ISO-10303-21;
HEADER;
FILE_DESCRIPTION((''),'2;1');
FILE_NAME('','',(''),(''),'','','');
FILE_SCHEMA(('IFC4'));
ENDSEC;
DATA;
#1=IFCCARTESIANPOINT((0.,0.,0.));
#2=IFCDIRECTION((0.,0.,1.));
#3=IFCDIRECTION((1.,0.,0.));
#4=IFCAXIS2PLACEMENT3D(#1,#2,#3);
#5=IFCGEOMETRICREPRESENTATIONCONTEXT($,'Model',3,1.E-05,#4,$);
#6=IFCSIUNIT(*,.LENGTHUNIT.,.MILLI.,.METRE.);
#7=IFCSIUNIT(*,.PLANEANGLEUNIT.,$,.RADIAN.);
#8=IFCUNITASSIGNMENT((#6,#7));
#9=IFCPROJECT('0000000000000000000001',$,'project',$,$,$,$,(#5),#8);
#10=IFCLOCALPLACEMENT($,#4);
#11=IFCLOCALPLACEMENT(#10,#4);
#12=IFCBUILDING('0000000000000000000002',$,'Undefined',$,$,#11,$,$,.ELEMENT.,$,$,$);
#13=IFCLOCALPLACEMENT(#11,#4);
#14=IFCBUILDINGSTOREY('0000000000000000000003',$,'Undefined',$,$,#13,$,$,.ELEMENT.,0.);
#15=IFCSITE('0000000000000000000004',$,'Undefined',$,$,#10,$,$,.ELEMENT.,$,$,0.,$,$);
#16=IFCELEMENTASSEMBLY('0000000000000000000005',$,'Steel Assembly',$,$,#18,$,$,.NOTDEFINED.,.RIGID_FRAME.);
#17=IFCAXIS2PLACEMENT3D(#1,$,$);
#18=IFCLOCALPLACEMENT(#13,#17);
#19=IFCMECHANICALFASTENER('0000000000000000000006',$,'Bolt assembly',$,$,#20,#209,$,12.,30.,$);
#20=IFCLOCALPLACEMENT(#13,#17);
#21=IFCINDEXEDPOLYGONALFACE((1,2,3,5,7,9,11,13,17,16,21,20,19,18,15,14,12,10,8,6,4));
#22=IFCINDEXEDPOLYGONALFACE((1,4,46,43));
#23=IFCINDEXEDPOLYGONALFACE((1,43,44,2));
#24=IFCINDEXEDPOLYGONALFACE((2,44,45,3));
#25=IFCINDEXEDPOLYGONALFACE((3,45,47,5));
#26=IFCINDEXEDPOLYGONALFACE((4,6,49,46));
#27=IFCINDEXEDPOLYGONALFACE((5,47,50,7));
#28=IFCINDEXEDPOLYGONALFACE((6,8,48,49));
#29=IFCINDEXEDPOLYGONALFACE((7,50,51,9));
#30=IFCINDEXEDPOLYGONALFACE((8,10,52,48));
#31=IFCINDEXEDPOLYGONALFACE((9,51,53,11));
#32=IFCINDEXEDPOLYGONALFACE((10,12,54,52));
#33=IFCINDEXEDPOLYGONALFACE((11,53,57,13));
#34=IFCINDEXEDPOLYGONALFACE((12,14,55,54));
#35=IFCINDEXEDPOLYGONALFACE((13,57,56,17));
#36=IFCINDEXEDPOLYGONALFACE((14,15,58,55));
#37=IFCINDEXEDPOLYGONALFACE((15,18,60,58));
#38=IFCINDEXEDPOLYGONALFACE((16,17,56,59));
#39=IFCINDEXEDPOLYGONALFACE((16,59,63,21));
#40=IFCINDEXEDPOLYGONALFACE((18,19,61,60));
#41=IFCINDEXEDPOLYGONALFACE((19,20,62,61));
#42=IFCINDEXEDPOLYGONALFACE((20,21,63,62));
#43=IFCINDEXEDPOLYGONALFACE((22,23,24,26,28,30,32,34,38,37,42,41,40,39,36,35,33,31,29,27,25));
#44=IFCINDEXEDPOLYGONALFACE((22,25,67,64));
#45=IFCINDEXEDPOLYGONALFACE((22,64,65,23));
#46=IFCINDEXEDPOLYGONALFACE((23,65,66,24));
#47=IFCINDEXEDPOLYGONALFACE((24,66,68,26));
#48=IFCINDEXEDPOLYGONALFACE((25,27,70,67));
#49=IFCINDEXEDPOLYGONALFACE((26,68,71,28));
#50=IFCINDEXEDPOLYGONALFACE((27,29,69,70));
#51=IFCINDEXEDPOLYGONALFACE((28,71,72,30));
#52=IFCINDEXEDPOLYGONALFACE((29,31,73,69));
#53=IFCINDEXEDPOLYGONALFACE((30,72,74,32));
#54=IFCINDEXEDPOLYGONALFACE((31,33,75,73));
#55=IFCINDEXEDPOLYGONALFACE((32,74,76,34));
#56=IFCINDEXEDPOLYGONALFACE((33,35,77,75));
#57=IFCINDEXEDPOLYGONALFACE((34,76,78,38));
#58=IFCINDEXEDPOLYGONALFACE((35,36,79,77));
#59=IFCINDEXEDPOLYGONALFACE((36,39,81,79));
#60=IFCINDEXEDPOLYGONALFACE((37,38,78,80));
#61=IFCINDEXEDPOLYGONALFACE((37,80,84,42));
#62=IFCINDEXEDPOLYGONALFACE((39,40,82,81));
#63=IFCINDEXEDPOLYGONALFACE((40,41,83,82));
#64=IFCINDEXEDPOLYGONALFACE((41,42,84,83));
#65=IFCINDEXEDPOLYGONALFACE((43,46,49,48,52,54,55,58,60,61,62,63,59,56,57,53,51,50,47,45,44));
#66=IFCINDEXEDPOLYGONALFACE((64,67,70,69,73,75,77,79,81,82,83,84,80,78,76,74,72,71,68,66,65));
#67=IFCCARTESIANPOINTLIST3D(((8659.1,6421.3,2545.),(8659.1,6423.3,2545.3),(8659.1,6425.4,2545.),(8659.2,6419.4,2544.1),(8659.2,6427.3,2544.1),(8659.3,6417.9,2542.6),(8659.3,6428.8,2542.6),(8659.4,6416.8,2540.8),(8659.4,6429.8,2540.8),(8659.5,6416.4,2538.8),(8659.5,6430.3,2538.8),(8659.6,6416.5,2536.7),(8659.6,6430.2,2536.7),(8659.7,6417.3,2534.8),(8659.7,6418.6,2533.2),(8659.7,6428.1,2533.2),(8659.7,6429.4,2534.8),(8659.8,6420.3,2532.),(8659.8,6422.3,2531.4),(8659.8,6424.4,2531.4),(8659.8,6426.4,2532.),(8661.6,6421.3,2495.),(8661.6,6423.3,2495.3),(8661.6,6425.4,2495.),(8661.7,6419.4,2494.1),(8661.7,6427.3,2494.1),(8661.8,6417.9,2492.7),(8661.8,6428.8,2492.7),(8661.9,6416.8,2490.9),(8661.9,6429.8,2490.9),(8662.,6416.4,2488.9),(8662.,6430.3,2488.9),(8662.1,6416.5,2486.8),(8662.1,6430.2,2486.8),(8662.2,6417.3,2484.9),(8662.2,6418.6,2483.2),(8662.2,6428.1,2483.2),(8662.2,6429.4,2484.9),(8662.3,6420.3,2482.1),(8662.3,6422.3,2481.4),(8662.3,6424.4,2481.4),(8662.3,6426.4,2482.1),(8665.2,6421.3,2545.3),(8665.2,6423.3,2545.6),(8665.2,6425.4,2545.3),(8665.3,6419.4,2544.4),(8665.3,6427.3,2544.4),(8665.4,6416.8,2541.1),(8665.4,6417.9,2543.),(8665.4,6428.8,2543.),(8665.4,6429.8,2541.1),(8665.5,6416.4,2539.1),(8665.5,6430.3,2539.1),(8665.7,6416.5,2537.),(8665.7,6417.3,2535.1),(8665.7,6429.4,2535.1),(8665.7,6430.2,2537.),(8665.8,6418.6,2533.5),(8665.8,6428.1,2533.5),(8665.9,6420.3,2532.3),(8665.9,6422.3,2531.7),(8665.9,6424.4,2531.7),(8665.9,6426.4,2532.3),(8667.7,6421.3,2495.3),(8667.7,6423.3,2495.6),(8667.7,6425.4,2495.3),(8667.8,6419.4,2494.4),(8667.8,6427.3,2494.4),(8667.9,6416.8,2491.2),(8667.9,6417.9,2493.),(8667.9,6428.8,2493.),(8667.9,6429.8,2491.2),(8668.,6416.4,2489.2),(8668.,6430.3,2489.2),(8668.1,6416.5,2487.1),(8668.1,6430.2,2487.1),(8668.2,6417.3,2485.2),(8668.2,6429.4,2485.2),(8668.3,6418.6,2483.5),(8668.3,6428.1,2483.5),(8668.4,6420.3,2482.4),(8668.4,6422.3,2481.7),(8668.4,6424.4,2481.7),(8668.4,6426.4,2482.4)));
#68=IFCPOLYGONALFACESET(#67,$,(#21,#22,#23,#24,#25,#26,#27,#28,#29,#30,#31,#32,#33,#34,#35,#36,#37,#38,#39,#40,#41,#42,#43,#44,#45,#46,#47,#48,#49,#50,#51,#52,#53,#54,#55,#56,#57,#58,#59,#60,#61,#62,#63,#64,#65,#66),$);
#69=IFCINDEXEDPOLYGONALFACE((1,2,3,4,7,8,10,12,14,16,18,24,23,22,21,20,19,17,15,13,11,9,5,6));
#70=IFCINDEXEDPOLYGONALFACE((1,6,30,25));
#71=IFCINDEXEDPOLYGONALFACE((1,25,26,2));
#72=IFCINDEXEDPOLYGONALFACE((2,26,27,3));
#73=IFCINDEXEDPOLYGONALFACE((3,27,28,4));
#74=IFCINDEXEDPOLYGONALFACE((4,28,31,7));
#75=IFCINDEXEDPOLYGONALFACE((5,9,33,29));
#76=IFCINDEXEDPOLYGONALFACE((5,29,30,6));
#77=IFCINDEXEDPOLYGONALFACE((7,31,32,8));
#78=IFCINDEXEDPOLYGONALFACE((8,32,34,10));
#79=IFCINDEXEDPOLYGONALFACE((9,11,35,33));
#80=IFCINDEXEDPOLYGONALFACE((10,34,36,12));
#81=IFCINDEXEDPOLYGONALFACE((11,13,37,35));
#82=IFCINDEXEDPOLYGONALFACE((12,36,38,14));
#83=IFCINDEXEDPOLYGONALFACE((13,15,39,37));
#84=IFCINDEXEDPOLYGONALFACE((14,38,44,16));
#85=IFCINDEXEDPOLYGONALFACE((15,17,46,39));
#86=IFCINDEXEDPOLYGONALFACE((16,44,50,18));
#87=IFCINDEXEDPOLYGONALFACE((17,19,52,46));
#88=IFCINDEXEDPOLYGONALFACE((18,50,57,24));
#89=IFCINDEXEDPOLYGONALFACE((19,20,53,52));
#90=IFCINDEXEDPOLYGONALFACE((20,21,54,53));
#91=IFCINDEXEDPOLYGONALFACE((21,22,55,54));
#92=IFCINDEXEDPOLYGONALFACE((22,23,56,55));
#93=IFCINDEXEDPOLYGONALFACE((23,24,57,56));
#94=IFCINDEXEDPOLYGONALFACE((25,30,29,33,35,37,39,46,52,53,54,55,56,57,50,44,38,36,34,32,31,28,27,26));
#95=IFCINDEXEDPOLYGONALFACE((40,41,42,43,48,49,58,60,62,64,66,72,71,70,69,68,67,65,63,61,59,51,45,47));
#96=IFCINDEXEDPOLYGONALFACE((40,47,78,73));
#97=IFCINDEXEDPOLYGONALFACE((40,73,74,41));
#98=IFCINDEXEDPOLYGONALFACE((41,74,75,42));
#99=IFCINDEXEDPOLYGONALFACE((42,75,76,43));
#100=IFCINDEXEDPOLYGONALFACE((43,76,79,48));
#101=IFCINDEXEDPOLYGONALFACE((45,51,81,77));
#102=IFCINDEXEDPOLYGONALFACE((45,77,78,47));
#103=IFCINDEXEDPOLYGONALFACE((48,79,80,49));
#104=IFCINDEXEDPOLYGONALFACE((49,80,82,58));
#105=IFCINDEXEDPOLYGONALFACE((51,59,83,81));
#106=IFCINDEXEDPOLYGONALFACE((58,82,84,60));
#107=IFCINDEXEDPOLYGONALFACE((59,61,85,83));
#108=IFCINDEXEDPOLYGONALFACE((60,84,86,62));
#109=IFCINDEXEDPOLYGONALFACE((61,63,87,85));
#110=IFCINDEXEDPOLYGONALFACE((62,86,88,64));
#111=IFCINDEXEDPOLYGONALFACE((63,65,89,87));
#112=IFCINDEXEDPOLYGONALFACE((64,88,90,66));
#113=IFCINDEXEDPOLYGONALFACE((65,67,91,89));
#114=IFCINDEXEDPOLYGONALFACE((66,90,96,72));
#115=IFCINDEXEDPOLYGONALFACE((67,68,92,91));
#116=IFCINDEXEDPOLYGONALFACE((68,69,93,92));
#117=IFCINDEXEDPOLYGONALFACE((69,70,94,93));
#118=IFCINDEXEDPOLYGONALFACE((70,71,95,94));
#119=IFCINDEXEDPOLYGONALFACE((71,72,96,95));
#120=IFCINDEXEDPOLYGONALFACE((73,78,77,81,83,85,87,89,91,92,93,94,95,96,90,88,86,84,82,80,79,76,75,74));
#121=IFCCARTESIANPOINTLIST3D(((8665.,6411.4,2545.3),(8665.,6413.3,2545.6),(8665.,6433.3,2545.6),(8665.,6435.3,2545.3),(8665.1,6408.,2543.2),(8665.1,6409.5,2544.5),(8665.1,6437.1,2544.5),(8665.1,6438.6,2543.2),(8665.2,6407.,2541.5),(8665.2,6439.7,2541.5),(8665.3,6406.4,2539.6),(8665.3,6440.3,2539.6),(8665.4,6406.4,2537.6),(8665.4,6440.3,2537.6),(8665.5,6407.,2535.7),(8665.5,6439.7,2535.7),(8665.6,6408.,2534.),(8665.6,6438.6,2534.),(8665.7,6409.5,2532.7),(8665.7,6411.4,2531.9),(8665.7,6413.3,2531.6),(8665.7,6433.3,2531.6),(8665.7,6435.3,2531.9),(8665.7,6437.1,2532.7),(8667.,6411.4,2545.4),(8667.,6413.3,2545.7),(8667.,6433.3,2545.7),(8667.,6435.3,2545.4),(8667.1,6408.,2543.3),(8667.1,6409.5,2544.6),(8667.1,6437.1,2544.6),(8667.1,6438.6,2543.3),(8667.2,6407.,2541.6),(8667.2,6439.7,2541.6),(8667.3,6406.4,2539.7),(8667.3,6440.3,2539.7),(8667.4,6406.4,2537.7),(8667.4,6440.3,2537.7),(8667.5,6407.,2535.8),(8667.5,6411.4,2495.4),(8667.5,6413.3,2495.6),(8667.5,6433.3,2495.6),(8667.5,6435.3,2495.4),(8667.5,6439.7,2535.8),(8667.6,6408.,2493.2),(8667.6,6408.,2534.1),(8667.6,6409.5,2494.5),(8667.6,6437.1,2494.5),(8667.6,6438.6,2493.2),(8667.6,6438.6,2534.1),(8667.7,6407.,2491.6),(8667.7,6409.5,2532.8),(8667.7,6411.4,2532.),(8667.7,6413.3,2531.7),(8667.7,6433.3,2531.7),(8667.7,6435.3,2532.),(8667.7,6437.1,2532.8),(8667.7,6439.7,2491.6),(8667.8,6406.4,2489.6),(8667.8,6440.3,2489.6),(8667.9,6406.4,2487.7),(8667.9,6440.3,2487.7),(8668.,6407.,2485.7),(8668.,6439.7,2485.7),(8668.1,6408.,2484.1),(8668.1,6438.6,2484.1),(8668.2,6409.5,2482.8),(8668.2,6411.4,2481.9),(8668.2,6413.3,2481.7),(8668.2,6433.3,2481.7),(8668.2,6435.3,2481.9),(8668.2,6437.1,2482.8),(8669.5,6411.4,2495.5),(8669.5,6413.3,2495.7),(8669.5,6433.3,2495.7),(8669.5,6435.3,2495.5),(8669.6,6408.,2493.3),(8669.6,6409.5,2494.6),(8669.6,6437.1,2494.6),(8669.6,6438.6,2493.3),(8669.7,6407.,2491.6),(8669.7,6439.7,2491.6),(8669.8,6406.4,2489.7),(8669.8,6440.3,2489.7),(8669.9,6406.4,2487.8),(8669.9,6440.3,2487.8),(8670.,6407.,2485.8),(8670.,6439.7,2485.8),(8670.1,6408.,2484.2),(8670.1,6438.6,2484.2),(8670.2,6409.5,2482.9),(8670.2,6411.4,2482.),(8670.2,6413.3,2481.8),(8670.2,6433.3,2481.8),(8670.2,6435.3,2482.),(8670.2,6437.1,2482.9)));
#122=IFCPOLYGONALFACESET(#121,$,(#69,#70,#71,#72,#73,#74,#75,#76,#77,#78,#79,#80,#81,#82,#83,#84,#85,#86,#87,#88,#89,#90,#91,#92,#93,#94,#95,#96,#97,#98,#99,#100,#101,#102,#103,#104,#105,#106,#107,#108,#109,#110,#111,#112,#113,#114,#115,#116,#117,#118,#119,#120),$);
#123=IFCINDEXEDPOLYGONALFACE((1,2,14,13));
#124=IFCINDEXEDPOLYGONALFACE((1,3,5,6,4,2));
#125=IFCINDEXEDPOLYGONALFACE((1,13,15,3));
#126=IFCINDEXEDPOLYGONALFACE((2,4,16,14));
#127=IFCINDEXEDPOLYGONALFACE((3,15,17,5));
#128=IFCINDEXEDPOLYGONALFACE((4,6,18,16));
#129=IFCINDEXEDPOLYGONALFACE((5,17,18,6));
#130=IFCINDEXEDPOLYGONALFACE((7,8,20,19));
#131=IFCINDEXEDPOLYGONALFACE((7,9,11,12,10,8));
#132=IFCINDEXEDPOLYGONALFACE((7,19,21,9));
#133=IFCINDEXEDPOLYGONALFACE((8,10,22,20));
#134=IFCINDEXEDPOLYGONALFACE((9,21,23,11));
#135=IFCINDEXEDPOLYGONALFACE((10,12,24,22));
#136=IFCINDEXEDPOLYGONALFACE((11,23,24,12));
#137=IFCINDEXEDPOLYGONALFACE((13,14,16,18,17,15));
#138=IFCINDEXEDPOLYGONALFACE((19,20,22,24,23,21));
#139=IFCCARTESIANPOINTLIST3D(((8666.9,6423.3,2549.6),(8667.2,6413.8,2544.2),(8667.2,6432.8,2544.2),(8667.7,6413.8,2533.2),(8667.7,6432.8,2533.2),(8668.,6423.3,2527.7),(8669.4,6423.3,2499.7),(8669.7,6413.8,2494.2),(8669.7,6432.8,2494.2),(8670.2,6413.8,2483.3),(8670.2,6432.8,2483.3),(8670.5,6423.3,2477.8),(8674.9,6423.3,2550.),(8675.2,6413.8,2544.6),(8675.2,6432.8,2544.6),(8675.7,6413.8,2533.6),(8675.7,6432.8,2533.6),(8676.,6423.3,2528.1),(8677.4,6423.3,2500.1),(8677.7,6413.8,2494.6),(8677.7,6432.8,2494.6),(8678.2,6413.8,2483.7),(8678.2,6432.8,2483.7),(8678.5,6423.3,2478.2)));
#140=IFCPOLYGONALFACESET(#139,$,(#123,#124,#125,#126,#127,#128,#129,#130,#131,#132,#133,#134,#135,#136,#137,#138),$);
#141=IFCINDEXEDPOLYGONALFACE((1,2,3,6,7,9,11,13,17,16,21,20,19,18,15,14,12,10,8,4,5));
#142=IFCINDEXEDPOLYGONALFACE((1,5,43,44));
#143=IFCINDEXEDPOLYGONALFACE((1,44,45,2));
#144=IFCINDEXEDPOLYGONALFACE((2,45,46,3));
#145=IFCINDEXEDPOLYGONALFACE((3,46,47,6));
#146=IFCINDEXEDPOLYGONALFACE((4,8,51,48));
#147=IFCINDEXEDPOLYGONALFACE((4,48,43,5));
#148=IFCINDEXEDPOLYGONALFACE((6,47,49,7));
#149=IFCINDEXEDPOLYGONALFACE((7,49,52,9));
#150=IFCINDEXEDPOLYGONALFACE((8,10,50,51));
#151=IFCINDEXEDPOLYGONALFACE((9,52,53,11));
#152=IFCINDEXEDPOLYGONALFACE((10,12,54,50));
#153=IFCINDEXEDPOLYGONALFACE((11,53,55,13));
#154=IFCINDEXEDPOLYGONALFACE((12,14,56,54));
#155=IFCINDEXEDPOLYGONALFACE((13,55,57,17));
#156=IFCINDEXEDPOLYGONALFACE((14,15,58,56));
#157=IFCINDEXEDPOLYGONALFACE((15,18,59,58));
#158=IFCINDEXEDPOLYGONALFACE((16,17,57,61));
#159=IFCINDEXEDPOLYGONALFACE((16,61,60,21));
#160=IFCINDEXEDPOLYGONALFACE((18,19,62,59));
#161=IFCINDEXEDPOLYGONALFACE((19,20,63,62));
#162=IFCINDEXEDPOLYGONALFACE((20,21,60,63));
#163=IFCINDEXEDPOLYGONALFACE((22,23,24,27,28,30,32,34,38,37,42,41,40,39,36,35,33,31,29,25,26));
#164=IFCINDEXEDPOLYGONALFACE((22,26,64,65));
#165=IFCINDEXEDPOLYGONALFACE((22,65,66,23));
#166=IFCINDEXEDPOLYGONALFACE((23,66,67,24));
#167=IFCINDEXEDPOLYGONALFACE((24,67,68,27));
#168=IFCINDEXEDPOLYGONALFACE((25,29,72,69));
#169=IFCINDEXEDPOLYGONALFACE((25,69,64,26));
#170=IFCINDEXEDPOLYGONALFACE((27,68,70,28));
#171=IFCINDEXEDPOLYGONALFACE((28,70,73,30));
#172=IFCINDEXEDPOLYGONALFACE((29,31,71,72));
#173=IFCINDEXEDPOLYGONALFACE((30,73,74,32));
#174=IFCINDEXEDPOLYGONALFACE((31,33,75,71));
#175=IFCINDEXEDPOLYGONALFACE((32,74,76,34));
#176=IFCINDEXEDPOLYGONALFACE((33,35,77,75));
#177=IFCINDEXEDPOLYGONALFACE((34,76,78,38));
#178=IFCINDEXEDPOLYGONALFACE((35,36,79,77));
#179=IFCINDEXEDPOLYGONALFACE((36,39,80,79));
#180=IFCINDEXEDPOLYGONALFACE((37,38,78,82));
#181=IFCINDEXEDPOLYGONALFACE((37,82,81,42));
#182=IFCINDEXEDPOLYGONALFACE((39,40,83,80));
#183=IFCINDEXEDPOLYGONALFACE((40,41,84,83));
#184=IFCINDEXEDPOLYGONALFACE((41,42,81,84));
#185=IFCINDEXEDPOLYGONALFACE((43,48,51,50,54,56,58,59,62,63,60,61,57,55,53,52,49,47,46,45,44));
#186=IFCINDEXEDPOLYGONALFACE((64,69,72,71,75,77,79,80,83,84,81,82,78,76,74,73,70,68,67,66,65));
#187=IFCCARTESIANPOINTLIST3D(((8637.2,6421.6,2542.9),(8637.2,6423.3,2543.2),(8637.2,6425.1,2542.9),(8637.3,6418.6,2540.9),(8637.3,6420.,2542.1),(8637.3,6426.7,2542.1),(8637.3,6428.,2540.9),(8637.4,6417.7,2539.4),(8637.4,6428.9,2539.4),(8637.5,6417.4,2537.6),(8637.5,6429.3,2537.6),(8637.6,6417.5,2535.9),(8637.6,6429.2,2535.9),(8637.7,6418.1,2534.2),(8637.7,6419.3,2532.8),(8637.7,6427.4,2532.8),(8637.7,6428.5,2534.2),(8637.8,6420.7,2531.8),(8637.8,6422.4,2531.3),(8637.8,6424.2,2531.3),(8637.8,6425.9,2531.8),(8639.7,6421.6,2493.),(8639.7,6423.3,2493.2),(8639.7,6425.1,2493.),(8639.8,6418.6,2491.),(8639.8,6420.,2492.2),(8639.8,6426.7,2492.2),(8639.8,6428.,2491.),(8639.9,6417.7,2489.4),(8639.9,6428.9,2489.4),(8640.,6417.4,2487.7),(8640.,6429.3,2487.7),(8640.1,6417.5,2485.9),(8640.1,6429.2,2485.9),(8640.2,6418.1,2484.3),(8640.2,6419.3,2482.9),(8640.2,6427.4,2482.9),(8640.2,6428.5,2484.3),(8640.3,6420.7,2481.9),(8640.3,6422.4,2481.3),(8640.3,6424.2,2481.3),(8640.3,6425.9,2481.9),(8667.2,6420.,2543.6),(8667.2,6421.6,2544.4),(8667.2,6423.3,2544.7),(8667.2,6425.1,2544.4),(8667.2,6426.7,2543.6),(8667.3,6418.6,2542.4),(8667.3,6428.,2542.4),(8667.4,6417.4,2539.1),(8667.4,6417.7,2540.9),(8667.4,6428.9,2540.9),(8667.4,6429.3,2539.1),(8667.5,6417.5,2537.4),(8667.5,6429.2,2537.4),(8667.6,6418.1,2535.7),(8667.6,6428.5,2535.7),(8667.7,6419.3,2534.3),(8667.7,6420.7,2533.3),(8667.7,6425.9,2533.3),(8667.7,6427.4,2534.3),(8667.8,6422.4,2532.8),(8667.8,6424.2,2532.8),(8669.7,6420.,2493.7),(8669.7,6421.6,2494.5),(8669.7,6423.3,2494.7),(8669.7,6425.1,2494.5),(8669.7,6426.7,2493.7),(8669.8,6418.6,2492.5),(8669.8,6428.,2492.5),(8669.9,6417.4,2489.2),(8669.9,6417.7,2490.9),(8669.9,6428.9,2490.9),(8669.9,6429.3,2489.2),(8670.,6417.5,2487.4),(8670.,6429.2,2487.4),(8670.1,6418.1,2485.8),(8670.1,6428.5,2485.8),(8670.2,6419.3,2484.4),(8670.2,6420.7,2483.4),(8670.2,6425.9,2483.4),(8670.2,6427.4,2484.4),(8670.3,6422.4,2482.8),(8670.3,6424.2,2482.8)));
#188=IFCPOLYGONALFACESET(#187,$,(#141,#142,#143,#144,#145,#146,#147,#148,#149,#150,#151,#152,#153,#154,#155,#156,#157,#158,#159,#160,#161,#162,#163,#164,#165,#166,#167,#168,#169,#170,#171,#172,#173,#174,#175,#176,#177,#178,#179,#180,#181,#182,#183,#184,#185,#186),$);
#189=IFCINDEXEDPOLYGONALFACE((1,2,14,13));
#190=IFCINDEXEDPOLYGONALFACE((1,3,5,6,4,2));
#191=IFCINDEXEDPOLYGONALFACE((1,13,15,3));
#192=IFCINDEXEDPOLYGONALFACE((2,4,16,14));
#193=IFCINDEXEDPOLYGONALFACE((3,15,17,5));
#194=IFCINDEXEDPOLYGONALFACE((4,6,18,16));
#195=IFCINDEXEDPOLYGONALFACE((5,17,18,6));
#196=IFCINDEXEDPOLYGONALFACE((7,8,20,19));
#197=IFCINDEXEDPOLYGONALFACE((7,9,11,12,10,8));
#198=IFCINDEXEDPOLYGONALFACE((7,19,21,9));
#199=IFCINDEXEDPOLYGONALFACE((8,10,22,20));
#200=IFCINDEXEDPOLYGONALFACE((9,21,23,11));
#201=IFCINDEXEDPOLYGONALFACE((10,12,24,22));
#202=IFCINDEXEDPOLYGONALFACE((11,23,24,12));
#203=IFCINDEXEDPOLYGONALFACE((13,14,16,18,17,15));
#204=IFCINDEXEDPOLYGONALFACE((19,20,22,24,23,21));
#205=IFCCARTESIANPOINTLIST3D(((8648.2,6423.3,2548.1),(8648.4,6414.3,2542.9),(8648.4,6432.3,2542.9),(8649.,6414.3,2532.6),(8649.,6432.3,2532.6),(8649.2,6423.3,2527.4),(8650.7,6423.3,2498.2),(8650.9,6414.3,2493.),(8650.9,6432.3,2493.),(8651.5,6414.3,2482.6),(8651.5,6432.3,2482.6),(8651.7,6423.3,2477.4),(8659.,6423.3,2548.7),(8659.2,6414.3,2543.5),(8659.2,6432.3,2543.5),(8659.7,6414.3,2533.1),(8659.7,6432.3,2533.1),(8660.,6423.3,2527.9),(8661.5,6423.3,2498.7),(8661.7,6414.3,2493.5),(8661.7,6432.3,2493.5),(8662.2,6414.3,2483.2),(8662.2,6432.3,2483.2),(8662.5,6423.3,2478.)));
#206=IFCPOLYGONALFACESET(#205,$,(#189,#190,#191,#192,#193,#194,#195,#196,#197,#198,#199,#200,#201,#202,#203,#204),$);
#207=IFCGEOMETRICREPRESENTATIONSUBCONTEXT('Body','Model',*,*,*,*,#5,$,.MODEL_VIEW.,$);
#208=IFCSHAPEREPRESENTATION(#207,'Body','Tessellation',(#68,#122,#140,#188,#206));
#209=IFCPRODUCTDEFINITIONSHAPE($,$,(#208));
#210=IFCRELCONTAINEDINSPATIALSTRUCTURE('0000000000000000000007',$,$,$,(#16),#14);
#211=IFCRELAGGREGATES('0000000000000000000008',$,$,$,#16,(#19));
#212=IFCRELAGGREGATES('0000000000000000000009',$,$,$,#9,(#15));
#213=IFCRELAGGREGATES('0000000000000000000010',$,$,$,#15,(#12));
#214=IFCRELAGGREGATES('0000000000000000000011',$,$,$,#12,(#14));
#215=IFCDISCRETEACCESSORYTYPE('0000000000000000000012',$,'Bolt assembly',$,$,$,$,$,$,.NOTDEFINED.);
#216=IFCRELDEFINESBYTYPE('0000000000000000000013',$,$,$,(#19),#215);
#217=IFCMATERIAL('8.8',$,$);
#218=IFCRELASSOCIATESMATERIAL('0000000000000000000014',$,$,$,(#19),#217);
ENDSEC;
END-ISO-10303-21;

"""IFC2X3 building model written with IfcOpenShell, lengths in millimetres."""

from ifc_helpers import new_model, si_unit, frame, frame_2d, origin_with_axes, origin_2d_with_axis, place, context, subcontext, project, spatial, polyline, circle_curve, parameter, trimmed, segment, composite_curve, circle, outline, extrude, source, transform, mapped, material, type_object, element, aggregate, save


model = new_model("IFC2X3")

# Units and contexts
model_context = context("Model", 3, precision=1e-05, world=origin_with_axes())
body_context = subcontext(model_context, "Body", "Model", "MODEL_VIEW")
ifc_project = project(units=[si_unit("LENGTHUNIT", "METRE", prefix="MILLI"), si_unit("PLANEANGLEUNIT", "RADIAN")], contexts=[model_context])

# Site, building, storey
site_placement = place(None, origin_with_axes())
site = spatial("IfcSite", under=ifc_project, at=site_placement, Name="Undefined", CompositionType="ELEMENT", RefElevation=0.0)
building_placement = place(site_placement, origin_with_axes())
building = spatial("IfcBuilding", under=site, at=building_placement, Name="Undefined", CompositionType="ELEMENT")
storey_placement = place(building_placement, origin_with_axes())
storey = spatial("IfcBuildingStorey", under=building, at=storey_placement, Name="Undefined", CompositionType="ELEMENT", Elevation=0.0)

# Element assembly
assembly_1_placement = place(storey_placement, origin_with_axes())
assembly_1 = element("IfcElementAssembly", 1, at=assembly_1_placement, inside=storey, Name="Steel Assembly", AssemblyPlace="NOTDEFINED", PredefinedType="RIGID_FRAME")

# Mechanical fastener
discrete_accessory_type_1 = type_object("IfcDiscreteAccessoryType", Name="Bolt assembly")
ifc_material_1 = material(Name="8.8")
shared_shape_1 = source(origin_with_axes(), body_context, "Body", "SweptSolid", [
    extrude(circle(Radius=7.0, at=origin_2d_with_axis()), frame((0.0, -3.1, 0.0), z_axis=(0.0, 1.0, 0.0), x_axis=(1.0, 0.0, 0.0)), (0.0, 0.0, 1.0), 6.1),
    extrude(outline(composite_curve([segment(polyline([(7.0, 10.0), (7.0, -10.0)]), True, "CONTINUOUS"), segment(trimmed(circle_curve(frame_2d((0.0, -10.0), x_axis=(1.0, 0.0)), 7.0), [parameter(0.0)], [parameter(3.1416)], False, "PARAMETER"), True, "CONTINUOUS"), segment(polyline([(-7.0, -10.0), (-7.0, 10.0)]), True, "CONTINUOUS"), segment(trimmed(circle_curve(frame_2d((0.0, 10.0), x_axis=(-1.0, 0.0)), 7.0), [parameter(0.0)], [parameter(3.1416)], False, "PARAMETER"), True, "DISCONTINUOUS")], self_intersect=False)), frame((0.0, -4.9, 0.0), z_axis=(0.0, 1.0, 0.0), x_axis=(1.0, 0.0, 0.0)), (0.0, 0.0, 1.0), 2.0),
    extrude(outline(polyline([(11.0, 0.0), (5.5, 9.5), (-5.5, 9.5), (-11.0, 0.0), (-5.5, -9.5), (5.5, -9.5), (11.0, 0.0)])), frame((0.0, -13.0, 0.0), z_axis=(0.0, 1.0, 0.0), x_axis=(1.0, 0.0, 0.0)), (0.0, 0.0, 1.0), 8.0),
    extrude(circle(Radius=6.0, at=origin_2d_with_axis()), frame((0.0, -5.0, 0.0), z_axis=(0.0, 1.0, 0.0), x_axis=(1.0, 0.0, 0.0)), (0.0, 0.0, 1.0), 30.0),
    extrude(outline(polyline([(10.4, 0.0), (5.2, 9.0), (-5.2, 9.0), (-10.4, 0.0), (-5.2, -9.0), (5.2, -9.0), (10.4, 0.0)])), frame((0.0, 3.0, 0.0), z_axis=(0.0, 1.0, 0.0), x_axis=(1.0, 0.0, 0.0)), (0.0, 0.0, 1.0), 10.8),
])
mechanical_fastener_1_placement = place(assembly_1_placement, frame((8666.2, 6468.3, 2463.5), z_axis=(0.0, -1.0, 0.0), x_axis=(-0.049938, 0.0, 0.998752)))
mechanical_fastener_1 = element("IfcMechanicalFastener", 2, at=mechanical_fastener_1_placement, type_object=discrete_accessory_type_1, material=ifc_material_1, Name="Bolt assembly", NominalDiameter=12.0, NominalLength=30.0, context=body_context, shape_type="MappedRepresentation", body=[
    mapped(shared_shape_1, transform((25.0, 0.0, 45.0))),
    mapped(shared_shape_1, transform((75.0, 0.0, 45.0))),
])
aggregate(assembly_1, [mechanical_fastener_1])

save(model, "model.ifc")
